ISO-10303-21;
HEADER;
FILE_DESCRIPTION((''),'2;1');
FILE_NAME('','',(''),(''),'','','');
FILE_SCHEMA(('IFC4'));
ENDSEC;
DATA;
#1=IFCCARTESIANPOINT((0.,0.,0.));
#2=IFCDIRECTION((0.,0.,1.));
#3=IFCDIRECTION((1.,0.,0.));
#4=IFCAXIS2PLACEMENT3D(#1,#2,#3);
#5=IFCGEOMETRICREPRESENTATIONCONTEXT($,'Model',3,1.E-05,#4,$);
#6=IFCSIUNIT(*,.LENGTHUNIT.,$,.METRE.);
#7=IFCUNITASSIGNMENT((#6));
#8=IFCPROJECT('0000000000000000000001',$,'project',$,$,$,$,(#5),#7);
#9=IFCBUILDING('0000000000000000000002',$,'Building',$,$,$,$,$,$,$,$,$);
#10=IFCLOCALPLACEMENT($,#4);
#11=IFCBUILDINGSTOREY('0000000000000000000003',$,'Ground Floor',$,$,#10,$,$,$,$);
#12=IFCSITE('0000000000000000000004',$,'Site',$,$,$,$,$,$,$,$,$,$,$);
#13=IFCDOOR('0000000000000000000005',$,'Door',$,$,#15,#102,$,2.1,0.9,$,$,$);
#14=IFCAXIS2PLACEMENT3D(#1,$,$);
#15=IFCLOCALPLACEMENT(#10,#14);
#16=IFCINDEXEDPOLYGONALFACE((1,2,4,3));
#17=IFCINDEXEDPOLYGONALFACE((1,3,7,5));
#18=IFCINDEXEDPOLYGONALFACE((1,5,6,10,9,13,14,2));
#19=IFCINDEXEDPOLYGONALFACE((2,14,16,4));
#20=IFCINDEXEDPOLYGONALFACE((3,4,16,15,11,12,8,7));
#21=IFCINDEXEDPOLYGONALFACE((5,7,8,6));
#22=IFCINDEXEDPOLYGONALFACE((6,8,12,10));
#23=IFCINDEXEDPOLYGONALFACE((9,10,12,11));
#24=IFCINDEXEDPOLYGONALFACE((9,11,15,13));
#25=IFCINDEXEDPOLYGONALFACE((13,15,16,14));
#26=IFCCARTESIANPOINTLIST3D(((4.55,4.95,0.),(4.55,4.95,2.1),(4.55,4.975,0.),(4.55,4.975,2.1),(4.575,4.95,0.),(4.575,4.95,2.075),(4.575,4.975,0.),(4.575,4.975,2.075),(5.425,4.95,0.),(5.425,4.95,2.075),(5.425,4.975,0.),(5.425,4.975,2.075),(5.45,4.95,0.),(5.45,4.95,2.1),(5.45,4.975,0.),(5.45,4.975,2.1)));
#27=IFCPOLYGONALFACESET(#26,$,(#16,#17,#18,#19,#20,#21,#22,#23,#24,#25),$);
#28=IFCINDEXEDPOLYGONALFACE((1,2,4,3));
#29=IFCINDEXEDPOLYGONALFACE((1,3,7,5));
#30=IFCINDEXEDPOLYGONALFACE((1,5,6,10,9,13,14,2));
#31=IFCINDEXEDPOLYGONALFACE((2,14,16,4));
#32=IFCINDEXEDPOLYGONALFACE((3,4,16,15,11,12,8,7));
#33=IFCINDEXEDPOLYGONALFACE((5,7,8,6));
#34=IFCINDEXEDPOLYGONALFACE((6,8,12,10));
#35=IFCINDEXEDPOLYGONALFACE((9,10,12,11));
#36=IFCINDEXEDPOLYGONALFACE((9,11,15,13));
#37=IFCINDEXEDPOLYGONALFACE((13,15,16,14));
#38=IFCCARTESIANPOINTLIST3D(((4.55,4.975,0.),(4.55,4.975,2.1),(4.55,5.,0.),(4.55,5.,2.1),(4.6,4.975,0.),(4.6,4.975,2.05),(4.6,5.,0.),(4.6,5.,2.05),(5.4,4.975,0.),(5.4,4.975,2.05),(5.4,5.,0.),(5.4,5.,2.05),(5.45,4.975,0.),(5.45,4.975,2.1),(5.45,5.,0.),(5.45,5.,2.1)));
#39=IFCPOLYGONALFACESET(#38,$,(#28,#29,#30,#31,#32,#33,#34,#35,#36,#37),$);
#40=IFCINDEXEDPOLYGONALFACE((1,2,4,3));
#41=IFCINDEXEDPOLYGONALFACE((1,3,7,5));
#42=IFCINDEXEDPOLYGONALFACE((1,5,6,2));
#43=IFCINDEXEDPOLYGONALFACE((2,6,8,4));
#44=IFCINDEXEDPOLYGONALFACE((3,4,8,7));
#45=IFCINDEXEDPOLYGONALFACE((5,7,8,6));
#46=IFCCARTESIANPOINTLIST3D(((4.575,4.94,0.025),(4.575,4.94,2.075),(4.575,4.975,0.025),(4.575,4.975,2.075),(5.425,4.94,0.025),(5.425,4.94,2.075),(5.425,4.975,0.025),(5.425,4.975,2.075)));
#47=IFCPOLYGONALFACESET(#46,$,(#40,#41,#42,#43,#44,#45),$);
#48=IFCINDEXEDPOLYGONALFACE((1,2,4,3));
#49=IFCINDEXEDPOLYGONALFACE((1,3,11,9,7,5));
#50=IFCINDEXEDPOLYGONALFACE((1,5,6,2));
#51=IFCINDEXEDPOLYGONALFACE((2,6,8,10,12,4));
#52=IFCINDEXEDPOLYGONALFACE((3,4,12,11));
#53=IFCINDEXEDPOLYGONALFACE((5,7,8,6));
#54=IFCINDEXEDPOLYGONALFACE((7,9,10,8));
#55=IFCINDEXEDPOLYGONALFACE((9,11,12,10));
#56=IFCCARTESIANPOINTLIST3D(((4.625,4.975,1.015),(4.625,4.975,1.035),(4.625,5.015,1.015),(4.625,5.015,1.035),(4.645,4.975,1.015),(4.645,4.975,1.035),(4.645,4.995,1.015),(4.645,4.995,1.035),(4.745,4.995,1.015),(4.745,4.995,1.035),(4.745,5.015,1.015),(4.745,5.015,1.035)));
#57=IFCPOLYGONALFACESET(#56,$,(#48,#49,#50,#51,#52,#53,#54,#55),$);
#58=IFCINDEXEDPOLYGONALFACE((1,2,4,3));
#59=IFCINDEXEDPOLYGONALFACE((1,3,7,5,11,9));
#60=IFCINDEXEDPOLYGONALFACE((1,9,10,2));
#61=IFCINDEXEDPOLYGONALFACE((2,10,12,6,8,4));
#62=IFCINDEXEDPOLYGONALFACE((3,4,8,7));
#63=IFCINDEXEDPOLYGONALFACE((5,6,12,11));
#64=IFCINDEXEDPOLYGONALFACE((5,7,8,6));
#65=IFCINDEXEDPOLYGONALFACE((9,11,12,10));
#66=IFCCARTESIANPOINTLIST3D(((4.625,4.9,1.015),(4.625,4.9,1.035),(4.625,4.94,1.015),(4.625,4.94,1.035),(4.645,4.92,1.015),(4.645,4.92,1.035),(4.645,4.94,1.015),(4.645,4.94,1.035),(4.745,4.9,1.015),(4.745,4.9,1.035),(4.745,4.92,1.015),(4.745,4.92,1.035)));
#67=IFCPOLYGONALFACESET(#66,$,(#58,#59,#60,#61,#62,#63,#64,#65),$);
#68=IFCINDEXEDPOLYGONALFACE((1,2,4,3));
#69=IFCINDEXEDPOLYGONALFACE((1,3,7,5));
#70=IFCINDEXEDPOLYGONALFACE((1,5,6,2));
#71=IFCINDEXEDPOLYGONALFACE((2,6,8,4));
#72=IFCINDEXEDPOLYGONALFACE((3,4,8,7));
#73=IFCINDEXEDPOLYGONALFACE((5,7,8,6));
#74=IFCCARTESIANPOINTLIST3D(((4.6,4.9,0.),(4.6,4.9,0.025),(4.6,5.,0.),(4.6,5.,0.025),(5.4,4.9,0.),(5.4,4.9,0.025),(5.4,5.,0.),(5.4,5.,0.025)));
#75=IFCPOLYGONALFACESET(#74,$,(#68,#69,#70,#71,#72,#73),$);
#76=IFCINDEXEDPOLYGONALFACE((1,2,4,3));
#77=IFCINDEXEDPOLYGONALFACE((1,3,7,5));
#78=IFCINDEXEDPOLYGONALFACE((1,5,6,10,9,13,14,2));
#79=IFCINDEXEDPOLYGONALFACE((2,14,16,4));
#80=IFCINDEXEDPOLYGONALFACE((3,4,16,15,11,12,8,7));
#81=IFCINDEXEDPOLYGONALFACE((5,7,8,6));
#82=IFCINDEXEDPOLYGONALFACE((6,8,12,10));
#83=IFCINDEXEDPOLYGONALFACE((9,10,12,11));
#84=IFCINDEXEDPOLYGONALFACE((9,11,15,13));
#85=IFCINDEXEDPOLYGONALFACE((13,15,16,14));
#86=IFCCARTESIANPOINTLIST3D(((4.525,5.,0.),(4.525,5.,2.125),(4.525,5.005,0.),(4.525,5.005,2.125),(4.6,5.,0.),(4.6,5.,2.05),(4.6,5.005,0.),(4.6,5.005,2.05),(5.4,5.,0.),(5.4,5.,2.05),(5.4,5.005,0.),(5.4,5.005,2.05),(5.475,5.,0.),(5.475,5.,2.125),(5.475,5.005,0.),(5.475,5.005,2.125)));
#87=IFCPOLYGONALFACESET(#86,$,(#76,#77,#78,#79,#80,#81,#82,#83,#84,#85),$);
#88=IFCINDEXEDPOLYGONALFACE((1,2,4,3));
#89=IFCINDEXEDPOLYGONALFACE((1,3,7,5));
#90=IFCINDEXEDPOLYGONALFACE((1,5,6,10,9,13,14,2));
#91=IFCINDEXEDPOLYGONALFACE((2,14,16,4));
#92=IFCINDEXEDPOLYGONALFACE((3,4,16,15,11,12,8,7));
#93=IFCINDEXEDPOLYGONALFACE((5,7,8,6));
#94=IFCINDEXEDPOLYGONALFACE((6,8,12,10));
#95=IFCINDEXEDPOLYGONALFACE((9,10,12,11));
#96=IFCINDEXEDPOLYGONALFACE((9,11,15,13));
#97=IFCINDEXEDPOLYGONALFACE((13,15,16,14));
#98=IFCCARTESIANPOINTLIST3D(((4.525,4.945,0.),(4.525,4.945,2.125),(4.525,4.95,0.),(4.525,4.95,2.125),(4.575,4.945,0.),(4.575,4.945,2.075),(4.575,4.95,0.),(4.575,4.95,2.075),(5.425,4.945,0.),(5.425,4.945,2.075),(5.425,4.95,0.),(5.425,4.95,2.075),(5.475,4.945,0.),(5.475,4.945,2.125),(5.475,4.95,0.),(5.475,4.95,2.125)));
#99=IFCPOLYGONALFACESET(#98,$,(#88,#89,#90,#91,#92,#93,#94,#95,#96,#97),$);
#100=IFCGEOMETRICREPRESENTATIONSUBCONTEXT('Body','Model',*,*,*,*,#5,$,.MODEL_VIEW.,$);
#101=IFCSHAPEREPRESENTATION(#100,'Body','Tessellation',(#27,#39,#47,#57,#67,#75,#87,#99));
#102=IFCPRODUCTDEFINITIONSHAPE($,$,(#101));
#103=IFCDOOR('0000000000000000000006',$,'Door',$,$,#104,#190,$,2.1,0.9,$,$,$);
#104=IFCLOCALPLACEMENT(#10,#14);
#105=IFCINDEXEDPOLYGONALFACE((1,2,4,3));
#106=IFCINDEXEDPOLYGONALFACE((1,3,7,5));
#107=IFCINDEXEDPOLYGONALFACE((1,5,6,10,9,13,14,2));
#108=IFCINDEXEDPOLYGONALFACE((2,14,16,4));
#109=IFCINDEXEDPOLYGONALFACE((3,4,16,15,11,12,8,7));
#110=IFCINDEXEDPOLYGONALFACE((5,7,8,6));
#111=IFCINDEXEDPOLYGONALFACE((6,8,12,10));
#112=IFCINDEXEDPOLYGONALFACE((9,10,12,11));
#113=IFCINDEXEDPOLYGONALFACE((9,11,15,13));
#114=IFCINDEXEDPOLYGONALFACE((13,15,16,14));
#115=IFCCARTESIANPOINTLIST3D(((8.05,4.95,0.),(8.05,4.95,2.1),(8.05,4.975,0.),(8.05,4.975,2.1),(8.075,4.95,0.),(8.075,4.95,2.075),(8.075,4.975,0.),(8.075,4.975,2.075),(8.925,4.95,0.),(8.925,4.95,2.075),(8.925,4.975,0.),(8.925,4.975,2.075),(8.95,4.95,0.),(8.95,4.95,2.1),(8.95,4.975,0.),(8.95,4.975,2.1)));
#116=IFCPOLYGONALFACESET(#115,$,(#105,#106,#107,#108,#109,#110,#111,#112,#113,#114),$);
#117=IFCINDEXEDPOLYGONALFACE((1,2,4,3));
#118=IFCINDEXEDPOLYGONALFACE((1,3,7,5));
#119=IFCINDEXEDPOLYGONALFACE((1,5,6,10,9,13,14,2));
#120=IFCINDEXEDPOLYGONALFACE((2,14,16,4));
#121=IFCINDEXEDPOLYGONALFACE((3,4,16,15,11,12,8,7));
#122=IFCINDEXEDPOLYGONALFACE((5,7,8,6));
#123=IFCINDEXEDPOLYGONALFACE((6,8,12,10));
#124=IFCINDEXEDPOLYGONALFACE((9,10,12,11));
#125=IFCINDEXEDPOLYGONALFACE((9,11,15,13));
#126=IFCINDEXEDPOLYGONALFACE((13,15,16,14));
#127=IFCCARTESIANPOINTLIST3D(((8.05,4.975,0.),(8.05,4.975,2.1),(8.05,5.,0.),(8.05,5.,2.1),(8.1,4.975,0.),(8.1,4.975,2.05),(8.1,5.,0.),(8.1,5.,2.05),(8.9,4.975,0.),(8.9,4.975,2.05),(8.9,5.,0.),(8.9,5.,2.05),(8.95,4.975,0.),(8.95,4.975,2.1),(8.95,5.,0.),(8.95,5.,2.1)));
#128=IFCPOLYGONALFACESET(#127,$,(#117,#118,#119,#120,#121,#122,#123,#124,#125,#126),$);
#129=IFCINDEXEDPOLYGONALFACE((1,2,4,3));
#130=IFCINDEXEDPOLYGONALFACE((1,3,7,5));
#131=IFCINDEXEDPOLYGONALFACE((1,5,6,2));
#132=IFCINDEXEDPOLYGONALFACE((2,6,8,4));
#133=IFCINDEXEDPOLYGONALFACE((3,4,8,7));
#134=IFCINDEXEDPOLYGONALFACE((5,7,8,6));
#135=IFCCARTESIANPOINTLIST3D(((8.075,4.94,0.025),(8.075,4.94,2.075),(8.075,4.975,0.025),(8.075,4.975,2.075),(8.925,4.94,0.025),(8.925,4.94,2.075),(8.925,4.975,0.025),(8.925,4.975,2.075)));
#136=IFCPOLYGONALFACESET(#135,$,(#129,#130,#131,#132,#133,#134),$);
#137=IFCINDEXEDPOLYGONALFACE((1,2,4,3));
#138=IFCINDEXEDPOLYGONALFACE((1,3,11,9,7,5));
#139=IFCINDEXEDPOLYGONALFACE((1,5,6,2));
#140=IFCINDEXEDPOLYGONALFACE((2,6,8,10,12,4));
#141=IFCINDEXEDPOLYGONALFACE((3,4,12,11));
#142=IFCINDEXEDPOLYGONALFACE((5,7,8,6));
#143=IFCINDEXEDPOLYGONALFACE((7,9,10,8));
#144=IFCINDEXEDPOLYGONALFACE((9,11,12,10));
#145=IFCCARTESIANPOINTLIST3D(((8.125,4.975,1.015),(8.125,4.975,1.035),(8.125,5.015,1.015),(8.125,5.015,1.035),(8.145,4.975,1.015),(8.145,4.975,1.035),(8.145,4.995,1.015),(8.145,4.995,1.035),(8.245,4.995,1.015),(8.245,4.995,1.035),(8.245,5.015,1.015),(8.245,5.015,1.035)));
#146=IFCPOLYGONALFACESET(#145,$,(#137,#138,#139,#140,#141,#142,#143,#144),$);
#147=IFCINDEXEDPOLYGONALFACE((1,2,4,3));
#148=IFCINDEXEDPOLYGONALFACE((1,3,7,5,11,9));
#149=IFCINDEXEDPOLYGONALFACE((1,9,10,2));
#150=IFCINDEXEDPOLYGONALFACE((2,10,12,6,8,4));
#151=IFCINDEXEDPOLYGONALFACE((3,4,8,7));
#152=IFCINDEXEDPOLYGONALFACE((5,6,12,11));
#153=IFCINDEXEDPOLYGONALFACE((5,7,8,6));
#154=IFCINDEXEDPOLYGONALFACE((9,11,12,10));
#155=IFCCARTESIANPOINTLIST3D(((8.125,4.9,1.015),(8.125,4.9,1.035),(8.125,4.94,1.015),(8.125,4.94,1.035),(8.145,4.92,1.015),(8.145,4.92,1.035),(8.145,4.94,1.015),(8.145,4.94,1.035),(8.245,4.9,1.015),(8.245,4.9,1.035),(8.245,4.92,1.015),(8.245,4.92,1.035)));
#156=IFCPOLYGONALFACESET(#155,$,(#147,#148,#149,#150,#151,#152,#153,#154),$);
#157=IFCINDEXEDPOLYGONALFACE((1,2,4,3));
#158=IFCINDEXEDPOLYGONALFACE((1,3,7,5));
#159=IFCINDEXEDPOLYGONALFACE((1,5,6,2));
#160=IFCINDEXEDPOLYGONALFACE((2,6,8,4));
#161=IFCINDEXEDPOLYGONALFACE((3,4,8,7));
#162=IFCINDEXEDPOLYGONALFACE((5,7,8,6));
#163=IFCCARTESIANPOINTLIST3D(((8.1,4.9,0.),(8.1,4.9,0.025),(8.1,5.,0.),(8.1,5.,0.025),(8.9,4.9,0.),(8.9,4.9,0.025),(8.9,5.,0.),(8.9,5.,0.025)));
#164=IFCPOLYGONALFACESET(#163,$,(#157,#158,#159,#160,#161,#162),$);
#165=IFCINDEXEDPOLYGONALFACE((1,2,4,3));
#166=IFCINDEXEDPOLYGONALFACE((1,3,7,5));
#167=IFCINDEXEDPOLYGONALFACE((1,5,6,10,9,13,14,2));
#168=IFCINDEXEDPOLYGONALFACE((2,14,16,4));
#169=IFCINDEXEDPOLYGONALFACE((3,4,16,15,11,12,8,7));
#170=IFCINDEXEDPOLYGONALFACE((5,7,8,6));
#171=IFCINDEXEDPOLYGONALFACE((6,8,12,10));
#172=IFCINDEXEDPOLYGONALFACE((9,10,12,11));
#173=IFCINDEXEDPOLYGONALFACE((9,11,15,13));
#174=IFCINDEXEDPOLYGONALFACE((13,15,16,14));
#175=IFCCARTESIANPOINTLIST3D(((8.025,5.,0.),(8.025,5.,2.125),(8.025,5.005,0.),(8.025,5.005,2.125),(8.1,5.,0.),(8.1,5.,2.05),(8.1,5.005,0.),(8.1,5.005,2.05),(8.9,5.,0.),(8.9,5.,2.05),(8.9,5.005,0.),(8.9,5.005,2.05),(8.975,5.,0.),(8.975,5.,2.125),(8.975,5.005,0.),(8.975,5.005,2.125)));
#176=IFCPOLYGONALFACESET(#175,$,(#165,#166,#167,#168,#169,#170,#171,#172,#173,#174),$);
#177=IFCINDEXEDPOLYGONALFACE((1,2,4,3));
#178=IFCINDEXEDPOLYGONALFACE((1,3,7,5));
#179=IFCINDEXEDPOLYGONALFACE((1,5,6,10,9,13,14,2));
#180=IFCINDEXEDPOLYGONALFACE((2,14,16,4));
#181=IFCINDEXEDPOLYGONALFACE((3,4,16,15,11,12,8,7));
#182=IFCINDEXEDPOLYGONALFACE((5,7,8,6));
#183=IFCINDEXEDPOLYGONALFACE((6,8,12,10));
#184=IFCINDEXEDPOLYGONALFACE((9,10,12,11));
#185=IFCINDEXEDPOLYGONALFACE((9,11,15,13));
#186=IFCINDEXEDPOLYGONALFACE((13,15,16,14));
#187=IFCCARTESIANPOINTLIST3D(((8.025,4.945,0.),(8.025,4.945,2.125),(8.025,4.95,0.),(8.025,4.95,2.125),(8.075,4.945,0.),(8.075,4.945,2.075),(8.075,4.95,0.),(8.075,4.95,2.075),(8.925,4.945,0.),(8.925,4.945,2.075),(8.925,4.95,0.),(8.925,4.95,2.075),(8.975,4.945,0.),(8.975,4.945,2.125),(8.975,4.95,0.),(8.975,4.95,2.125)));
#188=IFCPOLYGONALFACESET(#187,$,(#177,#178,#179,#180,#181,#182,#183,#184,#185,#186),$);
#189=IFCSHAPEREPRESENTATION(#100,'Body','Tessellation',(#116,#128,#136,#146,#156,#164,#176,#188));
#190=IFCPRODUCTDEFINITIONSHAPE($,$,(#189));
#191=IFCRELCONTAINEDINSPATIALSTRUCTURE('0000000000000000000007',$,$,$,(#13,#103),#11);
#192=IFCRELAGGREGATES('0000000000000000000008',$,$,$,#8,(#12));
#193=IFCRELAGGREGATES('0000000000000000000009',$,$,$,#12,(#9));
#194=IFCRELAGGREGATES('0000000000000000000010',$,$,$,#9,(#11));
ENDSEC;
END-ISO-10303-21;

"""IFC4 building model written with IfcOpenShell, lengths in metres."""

from ifc_helpers import new_model, si_unit, frame, origin_with_axes, place, context, subcontext, project, spatial, line, indexed_curve, outline, extrude, element, save


model = new_model("IFC4")

# Units and contexts
model_context = context("Model", 3, precision=1e-05, world=origin_with_axes())
body_context = subcontext(model_context, "Body", "Model", "MODEL_VIEW")
ifc_project = project(units=[si_unit("LENGTHUNIT", "METRE")], contexts=[model_context])

# Site, building, storey
site = spatial("IfcSite", under=ifc_project, Name="Site")
building = spatial("IfcBuilding", under=site, Name="Building")
storey_placement = place(None, origin_with_axes())
storey = spatial("IfcBuildingStorey", under=building, at=storey_placement, Name="Ground Floor")

# Doors
door_1_placement = place(storey_placement, frame((5.45, 5.0, 0.0), z_axis=(0.0, 0.0, 1.0), x_axis=(-1.0, 0.0, 0.0)))
element("IfcDoor", 1, at=door_1_placement, inside=storey, Name="Door", OverallHeight=2.1, OverallWidth=0.9, context=body_context, shape_type="SweptSolid", body=[
    extrude(outline(indexed_curve([(0.0, 0.0), (0.0, 2.1), (0.9, 2.1), (0.9, 0.0), (0.875, 0.0), (0.875, 2.075), (0.025, 2.075), (0.025, 0.0)], segments=[line(1, 2, 3, 4, 5, 6, 7, 8, 1)])), frame((0.0, 0.025, 0.0), z_axis=(0.0, -1.0, 0.0), x_axis=(1.0, 0.0, 0.0)), (0.0, 0.0, -1.0), 0.025),
    extrude(outline(indexed_curve([(0.0, 0.0), (0.0, 2.1), (0.9, 2.1), (0.9, 0.0), (0.85, 0.0), (0.85, 2.05), (0.05, 2.05), (0.05, 0.0)], segments=[line(1, 2, 3, 4, 5, 6, 7, 8, 1)])), frame((0.0, 0.0, 0.0), z_axis=(0.0, -1.0, 0.0), x_axis=(1.0, 0.0, 0.0)), (0.0, 0.0, -1.0), 0.025),
    extrude(outline(indexed_curve([(0.0, 0.0), (0.85, 0.0), (0.85, 0.035), (0.0, 0.035)], segments=[line(1, 2, 3, 4, 1)])), frame((0.025, 0.025, 0.025), z_axis=(0.0, 0.0, 1.0), x_axis=(1.0, 0.0, 0.0)), (0.0, 0.0, 1.0), 2.05),
    extrude(outline(indexed_curve([(0.0, 0.0), (0.0, -0.04), (-0.12, -0.04), (-0.12, -0.02), (-0.02, -0.02), (-0.02, 0.0)], segments=[line(1, 2, 3, 4, 5, 6, 1)])), frame((0.825, 0.025, 1.015), z_axis=(0.0, 0.0, 1.0), x_axis=(1.0, 0.0, 0.0)), (0.0, 0.0, 1.0), 0.02),
    extrude(outline(indexed_curve([(0.0, 0.0), (0.0, 0.04), (-0.12, 0.04), (-0.12, 0.02), (-0.02, 0.02), (-0.02, 0.0)], segments=[line(1, 2, 3, 4, 5, 6, 1)])), frame((0.825, 0.06, 1.015), z_axis=(0.0, 0.0, 1.0), x_axis=(1.0, 0.0, 0.0)), (0.0, 0.0, 1.0), 0.02),
    extrude(outline(indexed_curve([(0.0, 0.0), (0.8, 0.0), (0.8, 0.1), (0.0, 0.1)], segments=[line(1, 2, 3, 4, 1)])), frame((0.05, 0.0, 0.0), z_axis=(0.0, 0.0, 1.0), x_axis=(1.0, 0.0, 0.0)), (0.0, 0.0, 1.0), 0.025),
    extrude(outline(indexed_curve([(0.0, 0.0), (0.0, 2.125), (0.95, 2.125), (0.95, 0.0), (0.875, 0.0), (0.875, 2.05), (0.075, 2.05), (0.075, 0.0)], segments=[line(1, 2, 3, 4, 5, 6, 7, 8, 1)])), frame((-0.025, -0.005, 0.0), z_axis=(0.0, -1.0, 0.0), x_axis=(1.0, 0.0, 0.0)), (0.0, 0.0, -1.0), 0.005),
    extrude(outline(indexed_curve([(0.0, 0.0), (0.0, 2.125), (0.95, 2.125), (0.95, 0.0), (0.9, 0.0), (0.9, 2.075), (0.05, 2.075), (0.05, 0.0)], segments=[line(1, 2, 3, 4, 5, 6, 7, 8, 1)])), frame((-0.025, 0.05, 0.0), z_axis=(0.0, -1.0, 0.0), x_axis=(1.0, 0.0, 0.0)), (0.0, 0.0, -1.0), 0.005),
])
door_2_placement = place(storey_placement, frame((8.95, 5.0, 0.0), z_axis=(0.0, 0.0, 1.0), x_axis=(-1.0, 0.0, 0.0)))
element("IfcDoor", 2, at=door_2_placement, inside=storey, Name="Door", OverallHeight=2.1, OverallWidth=0.9, context=body_context, shape_type="SweptSolid", body=[
    extrude(outline(indexed_curve([(0.0, 0.0), (0.0, 2.1), (0.9, 2.1), (0.9, 0.0), (0.875, 0.0), (0.875, 2.075), (0.025, 2.075), (0.025, 0.0)], segments=[line(1, 2, 3, 4, 5, 6, 7, 8, 1)])), frame((0.0, 0.025, 0.0), z_axis=(0.0, -1.0, 0.0), x_axis=(1.0, 0.0, 0.0)), (0.0, 0.0, -1.0), 0.025),
    extrude(outline(indexed_curve([(0.0, 0.0), (0.0, 2.1), (0.9, 2.1), (0.9, 0.0), (0.85, 0.0), (0.85, 2.05), (0.05, 2.05), (0.05, 0.0)], segments=[line(1, 2, 3, 4, 5, 6, 7, 8, 1)])), frame((0.0, 0.0, 0.0), z_axis=(0.0, -1.0, 0.0), x_axis=(1.0, 0.0, 0.0)), (0.0, 0.0, -1.0), 0.025),
    extrude(outline(indexed_curve([(0.0, 0.0), (0.85, 0.0), (0.85, 0.035), (0.0, 0.035)], segments=[line(1, 2, 3, 4, 1)])), frame((0.025, 0.025, 0.025), z_axis=(0.0, 0.0, 1.0), x_axis=(1.0, 0.0, 0.0)), (0.0, 0.0, 1.0), 2.05),
    extrude(outline(indexed_curve([(0.0, 0.0), (0.0, -0.04), (-0.12, -0.04), (-0.12, -0.02), (-0.02, -0.02), (-0.02, 0.0)], segments=[line(1, 2, 3, 4, 5, 6, 1)])), frame((0.825, 0.025, 1.015), z_axis=(0.0, 0.0, 1.0), x_axis=(1.0, 0.0, 0.0)), (0.0, 0.0, 1.0), 0.02),
    extrude(outline(indexed_curve([(0.0, 0.0), (0.0, 0.04), (-0.12, 0.04), (-0.12, 0.02), (-0.02, 0.02), (-0.02, 0.0)], segments=[line(1, 2, 3, 4, 5, 6, 1)])), frame((0.825, 0.06, 1.015), z_axis=(0.0, 0.0, 1.0), x_axis=(1.0, 0.0, 0.0)), (0.0, 0.0, 1.0), 0.02),
    extrude(outline(indexed_curve([(0.0, 0.0), (0.8, 0.0), (0.8, 0.1), (0.0, 0.1)], segments=[line(1, 2, 3, 4, 1)])), frame((0.05, 0.0, 0.0), z_axis=(0.0, 0.0, 1.0), x_axis=(1.0, 0.0, 0.0)), (0.0, 0.0, 1.0), 0.025),
    extrude(outline(indexed_curve([(0.0, 0.0), (0.0, 2.125), (0.95, 2.125), (0.95, 0.0), (0.875, 0.0), (0.875, 2.05), (0.075, 2.05), (0.075, 0.0)], segments=[line(1, 2, 3, 4, 5, 6, 7, 8, 1)])), frame((-0.025, -0.005, 0.0), z_axis=(0.0, -1.0, 0.0), x_axis=(1.0, 0.0, 0.0)), (0.0, 0.0, -1.0), 0.005),
    extrude(outline(indexed_curve([(0.0, 0.0), (0.0, 2.125), (0.95, 2.125), (0.95, 0.0), (0.9, 0.0), (0.9, 2.075), (0.05, 2.075), (0.05, 0.0)], segments=[line(1, 2, 3, 4, 5, 6, 7, 8, 1)])), frame((-0.025, 0.05, 0.0), z_axis=(0.0, -1.0, 0.0), x_axis=(1.0, 0.0, 0.0)), (0.0, 0.0, -1.0), 0.005),
])

save(model, "model.ifc")
